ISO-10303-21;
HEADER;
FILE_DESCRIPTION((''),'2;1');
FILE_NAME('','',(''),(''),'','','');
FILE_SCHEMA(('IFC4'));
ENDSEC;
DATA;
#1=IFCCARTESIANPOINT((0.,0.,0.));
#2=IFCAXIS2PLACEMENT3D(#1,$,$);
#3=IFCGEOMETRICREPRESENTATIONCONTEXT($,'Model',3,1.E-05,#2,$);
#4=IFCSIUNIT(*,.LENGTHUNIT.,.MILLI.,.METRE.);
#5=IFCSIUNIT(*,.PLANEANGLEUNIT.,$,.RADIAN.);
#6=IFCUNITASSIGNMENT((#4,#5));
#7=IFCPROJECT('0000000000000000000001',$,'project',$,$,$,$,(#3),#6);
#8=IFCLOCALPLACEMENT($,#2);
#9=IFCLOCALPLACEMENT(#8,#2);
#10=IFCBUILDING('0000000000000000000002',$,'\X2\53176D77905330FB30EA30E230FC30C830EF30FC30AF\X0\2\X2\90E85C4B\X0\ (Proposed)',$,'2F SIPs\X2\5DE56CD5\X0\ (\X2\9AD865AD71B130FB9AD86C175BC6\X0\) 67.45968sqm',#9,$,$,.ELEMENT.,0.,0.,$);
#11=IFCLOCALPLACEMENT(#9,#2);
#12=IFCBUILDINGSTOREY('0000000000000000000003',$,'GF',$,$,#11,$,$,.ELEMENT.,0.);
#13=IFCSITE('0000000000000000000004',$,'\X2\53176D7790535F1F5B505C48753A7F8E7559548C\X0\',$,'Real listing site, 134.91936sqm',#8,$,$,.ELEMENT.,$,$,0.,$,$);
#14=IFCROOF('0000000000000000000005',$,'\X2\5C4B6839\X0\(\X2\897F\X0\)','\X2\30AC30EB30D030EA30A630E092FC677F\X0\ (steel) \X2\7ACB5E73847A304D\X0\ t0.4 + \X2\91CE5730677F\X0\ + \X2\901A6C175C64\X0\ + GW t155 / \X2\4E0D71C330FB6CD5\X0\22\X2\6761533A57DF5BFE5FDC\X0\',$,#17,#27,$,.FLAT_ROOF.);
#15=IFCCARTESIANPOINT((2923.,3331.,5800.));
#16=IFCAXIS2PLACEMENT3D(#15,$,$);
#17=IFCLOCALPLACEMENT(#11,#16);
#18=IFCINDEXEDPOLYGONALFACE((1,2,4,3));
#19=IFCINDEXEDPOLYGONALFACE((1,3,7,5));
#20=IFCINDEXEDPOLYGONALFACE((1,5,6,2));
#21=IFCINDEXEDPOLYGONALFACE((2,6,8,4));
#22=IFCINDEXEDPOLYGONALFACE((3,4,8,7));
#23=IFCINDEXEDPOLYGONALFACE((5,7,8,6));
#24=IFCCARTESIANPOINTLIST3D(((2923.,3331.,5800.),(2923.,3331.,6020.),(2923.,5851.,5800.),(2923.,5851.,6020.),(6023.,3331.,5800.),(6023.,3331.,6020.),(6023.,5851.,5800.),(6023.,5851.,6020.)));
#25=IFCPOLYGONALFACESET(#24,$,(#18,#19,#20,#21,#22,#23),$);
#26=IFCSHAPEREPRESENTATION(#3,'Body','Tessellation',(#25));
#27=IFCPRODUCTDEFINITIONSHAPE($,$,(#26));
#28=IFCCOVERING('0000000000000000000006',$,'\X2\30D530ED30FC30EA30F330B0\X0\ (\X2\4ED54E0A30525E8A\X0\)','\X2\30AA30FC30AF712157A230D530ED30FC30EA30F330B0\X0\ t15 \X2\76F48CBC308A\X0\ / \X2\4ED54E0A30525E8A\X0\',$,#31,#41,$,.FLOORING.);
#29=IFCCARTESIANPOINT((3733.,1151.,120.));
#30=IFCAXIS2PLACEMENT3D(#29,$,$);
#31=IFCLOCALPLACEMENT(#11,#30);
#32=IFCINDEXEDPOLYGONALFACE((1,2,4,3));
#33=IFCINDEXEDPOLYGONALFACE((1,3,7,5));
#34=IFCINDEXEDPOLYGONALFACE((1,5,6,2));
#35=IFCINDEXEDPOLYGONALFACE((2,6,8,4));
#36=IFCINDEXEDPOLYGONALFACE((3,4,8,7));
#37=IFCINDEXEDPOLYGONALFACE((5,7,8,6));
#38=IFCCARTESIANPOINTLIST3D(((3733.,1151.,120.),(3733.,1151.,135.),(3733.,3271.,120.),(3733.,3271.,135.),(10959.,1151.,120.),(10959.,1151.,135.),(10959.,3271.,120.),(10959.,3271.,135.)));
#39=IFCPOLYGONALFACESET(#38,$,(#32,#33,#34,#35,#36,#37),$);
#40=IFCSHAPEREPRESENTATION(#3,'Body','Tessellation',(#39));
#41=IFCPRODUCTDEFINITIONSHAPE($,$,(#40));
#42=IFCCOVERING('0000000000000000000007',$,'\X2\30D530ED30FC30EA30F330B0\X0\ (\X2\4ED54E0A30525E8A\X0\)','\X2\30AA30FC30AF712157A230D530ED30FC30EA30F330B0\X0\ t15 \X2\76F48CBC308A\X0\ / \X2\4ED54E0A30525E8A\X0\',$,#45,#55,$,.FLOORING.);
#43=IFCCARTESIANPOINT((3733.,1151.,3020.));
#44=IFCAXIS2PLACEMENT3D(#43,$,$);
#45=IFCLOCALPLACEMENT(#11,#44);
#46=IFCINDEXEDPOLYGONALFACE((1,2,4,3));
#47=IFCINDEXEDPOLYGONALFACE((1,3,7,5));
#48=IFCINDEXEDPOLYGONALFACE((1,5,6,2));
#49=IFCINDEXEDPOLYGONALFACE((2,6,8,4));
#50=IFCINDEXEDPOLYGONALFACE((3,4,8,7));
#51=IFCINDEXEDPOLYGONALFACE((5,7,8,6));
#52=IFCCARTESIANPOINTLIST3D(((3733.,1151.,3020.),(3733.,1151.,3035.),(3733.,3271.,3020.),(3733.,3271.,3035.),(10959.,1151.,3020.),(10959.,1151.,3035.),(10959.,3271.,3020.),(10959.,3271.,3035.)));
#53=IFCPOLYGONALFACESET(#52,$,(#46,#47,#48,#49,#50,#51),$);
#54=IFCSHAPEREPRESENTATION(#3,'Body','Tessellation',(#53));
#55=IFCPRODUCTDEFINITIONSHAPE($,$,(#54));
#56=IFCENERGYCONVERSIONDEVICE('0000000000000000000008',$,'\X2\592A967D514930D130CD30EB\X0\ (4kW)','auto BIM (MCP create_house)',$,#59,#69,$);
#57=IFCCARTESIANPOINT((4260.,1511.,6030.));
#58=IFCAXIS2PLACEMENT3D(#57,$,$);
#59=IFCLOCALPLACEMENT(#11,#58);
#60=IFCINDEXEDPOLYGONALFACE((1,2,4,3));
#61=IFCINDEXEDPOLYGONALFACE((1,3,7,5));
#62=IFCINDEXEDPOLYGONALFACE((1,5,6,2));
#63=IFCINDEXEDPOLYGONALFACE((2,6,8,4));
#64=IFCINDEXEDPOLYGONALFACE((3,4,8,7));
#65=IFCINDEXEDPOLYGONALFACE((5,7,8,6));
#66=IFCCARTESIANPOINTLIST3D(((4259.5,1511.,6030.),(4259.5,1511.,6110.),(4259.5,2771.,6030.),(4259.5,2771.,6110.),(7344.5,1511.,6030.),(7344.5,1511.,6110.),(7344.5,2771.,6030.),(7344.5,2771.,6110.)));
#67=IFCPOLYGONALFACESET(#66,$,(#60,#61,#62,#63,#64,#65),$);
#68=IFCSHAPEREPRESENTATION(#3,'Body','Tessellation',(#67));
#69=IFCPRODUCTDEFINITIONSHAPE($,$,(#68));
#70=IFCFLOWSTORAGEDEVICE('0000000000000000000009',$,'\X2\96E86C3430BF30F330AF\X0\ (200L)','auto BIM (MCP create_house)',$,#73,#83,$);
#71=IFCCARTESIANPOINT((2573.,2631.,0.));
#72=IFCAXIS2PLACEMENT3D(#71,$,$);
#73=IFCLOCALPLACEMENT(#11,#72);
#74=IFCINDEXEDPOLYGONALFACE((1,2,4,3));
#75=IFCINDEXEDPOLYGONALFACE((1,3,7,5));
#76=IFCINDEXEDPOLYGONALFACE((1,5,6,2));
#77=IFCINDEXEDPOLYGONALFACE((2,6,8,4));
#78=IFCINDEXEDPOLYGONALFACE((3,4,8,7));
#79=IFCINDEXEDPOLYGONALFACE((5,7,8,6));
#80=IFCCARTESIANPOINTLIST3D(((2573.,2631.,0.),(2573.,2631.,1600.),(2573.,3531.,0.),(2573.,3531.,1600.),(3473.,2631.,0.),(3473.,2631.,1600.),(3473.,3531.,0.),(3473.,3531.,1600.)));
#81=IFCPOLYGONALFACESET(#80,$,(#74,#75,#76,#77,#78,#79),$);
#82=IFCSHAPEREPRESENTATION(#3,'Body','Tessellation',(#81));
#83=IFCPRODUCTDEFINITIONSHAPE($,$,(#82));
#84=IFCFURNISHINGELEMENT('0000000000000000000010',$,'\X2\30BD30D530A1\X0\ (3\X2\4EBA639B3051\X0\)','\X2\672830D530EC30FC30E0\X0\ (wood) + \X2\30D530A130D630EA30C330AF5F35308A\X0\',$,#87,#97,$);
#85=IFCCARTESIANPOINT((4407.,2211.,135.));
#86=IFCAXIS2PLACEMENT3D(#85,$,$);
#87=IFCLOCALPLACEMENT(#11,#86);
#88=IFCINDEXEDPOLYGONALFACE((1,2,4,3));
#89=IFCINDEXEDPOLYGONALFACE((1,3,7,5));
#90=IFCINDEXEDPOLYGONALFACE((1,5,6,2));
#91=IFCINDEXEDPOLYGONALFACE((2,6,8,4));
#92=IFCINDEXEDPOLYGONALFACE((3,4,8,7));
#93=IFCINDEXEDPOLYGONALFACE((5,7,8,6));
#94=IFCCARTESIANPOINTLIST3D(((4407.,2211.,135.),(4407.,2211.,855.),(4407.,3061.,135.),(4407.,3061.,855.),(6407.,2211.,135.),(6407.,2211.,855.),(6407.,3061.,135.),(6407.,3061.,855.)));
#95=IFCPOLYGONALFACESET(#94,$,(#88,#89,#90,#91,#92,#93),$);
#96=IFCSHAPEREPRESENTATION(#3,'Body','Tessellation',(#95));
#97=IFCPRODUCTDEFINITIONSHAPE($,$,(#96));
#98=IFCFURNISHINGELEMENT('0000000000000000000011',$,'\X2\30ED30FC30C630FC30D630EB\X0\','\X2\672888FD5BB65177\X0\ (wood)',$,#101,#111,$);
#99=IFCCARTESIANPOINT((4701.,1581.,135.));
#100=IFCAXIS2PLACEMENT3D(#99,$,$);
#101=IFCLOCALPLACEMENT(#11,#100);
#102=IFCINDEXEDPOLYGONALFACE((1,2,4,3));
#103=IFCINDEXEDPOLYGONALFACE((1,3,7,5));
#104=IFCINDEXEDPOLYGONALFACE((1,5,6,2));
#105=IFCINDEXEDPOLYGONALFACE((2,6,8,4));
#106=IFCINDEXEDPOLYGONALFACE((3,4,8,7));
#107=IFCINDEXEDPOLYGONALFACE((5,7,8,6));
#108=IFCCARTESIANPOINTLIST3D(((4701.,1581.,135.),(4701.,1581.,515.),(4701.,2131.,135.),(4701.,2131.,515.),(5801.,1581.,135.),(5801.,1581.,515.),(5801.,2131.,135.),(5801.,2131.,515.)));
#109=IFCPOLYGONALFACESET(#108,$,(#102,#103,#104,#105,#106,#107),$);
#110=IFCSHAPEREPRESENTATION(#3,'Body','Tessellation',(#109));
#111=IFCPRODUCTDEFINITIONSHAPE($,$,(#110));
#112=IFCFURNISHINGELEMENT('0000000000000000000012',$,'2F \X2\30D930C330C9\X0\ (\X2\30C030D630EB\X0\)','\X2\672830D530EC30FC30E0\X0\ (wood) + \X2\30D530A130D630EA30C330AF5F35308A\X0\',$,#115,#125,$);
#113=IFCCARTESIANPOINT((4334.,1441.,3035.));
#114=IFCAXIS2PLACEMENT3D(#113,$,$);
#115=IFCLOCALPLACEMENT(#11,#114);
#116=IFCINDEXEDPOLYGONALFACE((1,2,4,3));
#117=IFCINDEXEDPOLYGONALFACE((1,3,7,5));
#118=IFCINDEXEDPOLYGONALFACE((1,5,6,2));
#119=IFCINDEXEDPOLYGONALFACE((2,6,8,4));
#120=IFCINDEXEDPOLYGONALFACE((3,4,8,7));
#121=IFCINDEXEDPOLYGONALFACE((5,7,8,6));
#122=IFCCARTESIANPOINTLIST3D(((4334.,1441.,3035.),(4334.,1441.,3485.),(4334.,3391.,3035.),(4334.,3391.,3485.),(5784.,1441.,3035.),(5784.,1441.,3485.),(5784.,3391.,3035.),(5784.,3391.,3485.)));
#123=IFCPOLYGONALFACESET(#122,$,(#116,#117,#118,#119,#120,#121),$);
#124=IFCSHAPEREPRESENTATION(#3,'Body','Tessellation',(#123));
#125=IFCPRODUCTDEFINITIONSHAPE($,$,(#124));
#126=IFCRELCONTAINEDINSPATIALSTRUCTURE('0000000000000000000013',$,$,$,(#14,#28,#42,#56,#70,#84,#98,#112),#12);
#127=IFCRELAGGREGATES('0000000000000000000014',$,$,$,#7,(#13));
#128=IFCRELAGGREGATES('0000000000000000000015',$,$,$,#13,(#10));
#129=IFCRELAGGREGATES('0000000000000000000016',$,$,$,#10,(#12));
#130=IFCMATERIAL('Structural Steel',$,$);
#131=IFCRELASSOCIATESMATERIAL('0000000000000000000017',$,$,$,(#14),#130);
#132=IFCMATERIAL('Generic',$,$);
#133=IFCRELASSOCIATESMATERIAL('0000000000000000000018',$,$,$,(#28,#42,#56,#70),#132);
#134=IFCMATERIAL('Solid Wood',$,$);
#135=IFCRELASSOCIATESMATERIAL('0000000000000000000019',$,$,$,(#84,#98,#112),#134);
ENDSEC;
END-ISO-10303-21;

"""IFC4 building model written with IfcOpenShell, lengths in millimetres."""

from ifc_helpers import new_model, si_unit, frame, frame_2d, origin, place, context, project, spatial, rectangle, extrude, material, element, save


model = new_model("IFC4")

# Units and contexts
model_context = context("Model", 3, precision=1e-05, world=origin())
ifc_project = project(units=[si_unit("LENGTHUNIT", "METRE", prefix="MILLI"), si_unit("PLANEANGLEUNIT", "RADIAN")], contexts=[model_context])

# Site, building, storey
site_placement = place(None, origin())
site = spatial("IfcSite", under=ifc_project, at=site_placement, Name="北海道弟子屈町美留和", ObjectType="Real listing site, 134.91936sqm", CompositionType="ELEMENT", RefElevation=0.0)
building_placement = place(site_placement, origin())
building = spatial("IfcBuilding", under=site, at=building_placement, Name="北海道・リモートワーク2部屋 (Proposed)", ObjectType="2F SIPs工法 (高断熱・高気密) 67.45968sqm", CompositionType="ELEMENT", ElevationOfRefHeight=0.0, ElevationOfTerrain=0.0)
storey_placement = place(building_placement, origin())
storey = spatial("IfcBuildingStorey", under=building, at=storey_placement, Name="GF", CompositionType="ELEMENT", Elevation=0.0)

# Shared definitions
ifc_material_1 = material(Name="Solid Wood")

# Roof
ifc_material_2 = material(Name="Structural Steel")
roof_1_placement = place(storey_placement, frame((2923.0, 3331.0, 5800.0)))
element("IfcRoof", 1, at=roof_1_placement, inside=storey, material=ifc_material_2, Name="屋根(西)", Description="ガルバリウム鋼板 (steel) 立平葺き t0.4 + 野地板 + 通気層 + GW t155 / 不燃・法22条区域対応", PredefinedType="FLAT_ROOF", context=model_context, shape_type="SweptSolid", body=[
    extrude(rectangle(XDim=3100.0, YDim=2520.0, at=frame_2d((1550.0, 1260.0))), frame((2923.0, 3331.0, 5800.0)), (0.0, 0.0, 1.0), 220.0),
])

# Coverings
ifc_material_3 = material(Name="Generic")
covering_1_placement = place(storey_placement, frame((3733.0, 1151.0, 120.0)))
element("IfcCovering", 2, at=covering_1_placement, inside=storey, material=ifc_material_3, Name="フローリング (仕上げ床)", Description="オーク無垢フローリング t15 直貼り / 仕上げ床", PredefinedType="FLOORING", context=model_context, shape_type="SweptSolid", body=[
    extrude(rectangle(XDim=7226.0, YDim=2120.0, at=frame_2d((3613.0, 1060.0))), frame((3733.0, 1151.0, 120.0)), (0.0, 0.0, 1.0), 15.0),
])
covering_2_placement = place(storey_placement, frame((3733.0, 1151.0, 3020.0)))
element("IfcCovering", 3, at=covering_2_placement, inside=storey, material=ifc_material_3, Name="フローリング (仕上げ床)", Description="オーク無垢フローリング t15 直貼り / 仕上げ床", PredefinedType="FLOORING", context=model_context, shape_type="SweptSolid", body=[
    extrude(rectangle(XDim=7226.0, YDim=2120.0, at=frame_2d((3613.0, 1060.0))), frame((3733.0, 1151.0, 3020.0)), (0.0, 0.0, 1.0), 15.0),
])

# Energy conversion device
energy_conversion_device_placement = place(storey_placement, frame((4260.0, 1511.0, 6030.0)))
element("IfcEnergyConversionDevice", 4, at=energy_conversion_device_placement, inside=storey, material=ifc_material_3, Name="太陽光パネル (4kW)", Description="auto BIM (MCP create_house)", context=model_context, shape_type="SweptSolid", body=[
    extrude(rectangle(XDim=3085.0, YDim=1260.0, at=frame_2d((1542.0, 630.0))), frame((4260.0, 1511.0, 6030.0)), (0.0, 0.0, 1.0), 80.0),
])

# Flow storage device
flow_storage_device_placement = place(storey_placement, frame((2573.0, 2631.0, 0.0)))
element("IfcFlowStorageDevice", 5, at=flow_storage_device_placement, inside=storey, material=ifc_material_3, Name="雨水タンク (200L)", Description="auto BIM (MCP create_house)", context=model_context, shape_type="SweptSolid", body=[
    extrude(rectangle(XDim=900.0, YDim=900.0, at=frame_2d((450.0, 450.0))), frame((2573.0, 2631.0, 0.0)), (0.0, 0.0, 1.0), 1600.0),
])

# Furnishing elements
furnishing_1_placement = place(storey_placement, frame((4407.0, 2211.0, 135.0)))
element("IfcFurnishingElement", 6, at=furnishing_1_placement, inside=storey, material=ifc_material_1, Name="ソファ (3人掛け)", Description="木フレーム (wood) + ファブリック張り", context=model_context, shape_type="SweptSolid", body=[
    extrude(rectangle(XDim=2000.0, YDim=850.0, at=frame_2d((1000.0, 425.0))), frame((4407.0, 2211.0, 135.0)), (0.0, 0.0, 1.0), 720.0),
])
furnishing_2_placement = place(storey_placement, frame((4701.0, 1581.0, 135.0)))
element("IfcFurnishingElement", 7, at=furnishing_2_placement, inside=storey, material=ifc_material_1, Name="ローテーブル", Description="木製家具 (wood)", context=model_context, shape_type="SweptSolid", body=[
    extrude(rectangle(XDim=1100.0, YDim=550.0, at=frame_2d((550.0, 275.0))), frame((4701.0, 1581.0, 135.0)), (0.0, 0.0, 1.0), 380.0),
])
furnishing_3_placement = place(storey_placement, frame((4334.0, 1441.0, 3035.0)))
element("IfcFurnishingElement", 8, at=furnishing_3_placement, inside=storey, material=ifc_material_1, Name="2F ベッド (ダブル)", Description="木フレーム (wood) + ファブリック張り", context=model_context, shape_type="SweptSolid", body=[
    extrude(rectangle(XDim=1450.0, YDim=1950.0, at=frame_2d((725.0, 975.0))), frame((4334.0, 1441.0, 3035.0)), (0.0, 0.0, 1.0), 450.0),
])

save(model, "model.ifc")
